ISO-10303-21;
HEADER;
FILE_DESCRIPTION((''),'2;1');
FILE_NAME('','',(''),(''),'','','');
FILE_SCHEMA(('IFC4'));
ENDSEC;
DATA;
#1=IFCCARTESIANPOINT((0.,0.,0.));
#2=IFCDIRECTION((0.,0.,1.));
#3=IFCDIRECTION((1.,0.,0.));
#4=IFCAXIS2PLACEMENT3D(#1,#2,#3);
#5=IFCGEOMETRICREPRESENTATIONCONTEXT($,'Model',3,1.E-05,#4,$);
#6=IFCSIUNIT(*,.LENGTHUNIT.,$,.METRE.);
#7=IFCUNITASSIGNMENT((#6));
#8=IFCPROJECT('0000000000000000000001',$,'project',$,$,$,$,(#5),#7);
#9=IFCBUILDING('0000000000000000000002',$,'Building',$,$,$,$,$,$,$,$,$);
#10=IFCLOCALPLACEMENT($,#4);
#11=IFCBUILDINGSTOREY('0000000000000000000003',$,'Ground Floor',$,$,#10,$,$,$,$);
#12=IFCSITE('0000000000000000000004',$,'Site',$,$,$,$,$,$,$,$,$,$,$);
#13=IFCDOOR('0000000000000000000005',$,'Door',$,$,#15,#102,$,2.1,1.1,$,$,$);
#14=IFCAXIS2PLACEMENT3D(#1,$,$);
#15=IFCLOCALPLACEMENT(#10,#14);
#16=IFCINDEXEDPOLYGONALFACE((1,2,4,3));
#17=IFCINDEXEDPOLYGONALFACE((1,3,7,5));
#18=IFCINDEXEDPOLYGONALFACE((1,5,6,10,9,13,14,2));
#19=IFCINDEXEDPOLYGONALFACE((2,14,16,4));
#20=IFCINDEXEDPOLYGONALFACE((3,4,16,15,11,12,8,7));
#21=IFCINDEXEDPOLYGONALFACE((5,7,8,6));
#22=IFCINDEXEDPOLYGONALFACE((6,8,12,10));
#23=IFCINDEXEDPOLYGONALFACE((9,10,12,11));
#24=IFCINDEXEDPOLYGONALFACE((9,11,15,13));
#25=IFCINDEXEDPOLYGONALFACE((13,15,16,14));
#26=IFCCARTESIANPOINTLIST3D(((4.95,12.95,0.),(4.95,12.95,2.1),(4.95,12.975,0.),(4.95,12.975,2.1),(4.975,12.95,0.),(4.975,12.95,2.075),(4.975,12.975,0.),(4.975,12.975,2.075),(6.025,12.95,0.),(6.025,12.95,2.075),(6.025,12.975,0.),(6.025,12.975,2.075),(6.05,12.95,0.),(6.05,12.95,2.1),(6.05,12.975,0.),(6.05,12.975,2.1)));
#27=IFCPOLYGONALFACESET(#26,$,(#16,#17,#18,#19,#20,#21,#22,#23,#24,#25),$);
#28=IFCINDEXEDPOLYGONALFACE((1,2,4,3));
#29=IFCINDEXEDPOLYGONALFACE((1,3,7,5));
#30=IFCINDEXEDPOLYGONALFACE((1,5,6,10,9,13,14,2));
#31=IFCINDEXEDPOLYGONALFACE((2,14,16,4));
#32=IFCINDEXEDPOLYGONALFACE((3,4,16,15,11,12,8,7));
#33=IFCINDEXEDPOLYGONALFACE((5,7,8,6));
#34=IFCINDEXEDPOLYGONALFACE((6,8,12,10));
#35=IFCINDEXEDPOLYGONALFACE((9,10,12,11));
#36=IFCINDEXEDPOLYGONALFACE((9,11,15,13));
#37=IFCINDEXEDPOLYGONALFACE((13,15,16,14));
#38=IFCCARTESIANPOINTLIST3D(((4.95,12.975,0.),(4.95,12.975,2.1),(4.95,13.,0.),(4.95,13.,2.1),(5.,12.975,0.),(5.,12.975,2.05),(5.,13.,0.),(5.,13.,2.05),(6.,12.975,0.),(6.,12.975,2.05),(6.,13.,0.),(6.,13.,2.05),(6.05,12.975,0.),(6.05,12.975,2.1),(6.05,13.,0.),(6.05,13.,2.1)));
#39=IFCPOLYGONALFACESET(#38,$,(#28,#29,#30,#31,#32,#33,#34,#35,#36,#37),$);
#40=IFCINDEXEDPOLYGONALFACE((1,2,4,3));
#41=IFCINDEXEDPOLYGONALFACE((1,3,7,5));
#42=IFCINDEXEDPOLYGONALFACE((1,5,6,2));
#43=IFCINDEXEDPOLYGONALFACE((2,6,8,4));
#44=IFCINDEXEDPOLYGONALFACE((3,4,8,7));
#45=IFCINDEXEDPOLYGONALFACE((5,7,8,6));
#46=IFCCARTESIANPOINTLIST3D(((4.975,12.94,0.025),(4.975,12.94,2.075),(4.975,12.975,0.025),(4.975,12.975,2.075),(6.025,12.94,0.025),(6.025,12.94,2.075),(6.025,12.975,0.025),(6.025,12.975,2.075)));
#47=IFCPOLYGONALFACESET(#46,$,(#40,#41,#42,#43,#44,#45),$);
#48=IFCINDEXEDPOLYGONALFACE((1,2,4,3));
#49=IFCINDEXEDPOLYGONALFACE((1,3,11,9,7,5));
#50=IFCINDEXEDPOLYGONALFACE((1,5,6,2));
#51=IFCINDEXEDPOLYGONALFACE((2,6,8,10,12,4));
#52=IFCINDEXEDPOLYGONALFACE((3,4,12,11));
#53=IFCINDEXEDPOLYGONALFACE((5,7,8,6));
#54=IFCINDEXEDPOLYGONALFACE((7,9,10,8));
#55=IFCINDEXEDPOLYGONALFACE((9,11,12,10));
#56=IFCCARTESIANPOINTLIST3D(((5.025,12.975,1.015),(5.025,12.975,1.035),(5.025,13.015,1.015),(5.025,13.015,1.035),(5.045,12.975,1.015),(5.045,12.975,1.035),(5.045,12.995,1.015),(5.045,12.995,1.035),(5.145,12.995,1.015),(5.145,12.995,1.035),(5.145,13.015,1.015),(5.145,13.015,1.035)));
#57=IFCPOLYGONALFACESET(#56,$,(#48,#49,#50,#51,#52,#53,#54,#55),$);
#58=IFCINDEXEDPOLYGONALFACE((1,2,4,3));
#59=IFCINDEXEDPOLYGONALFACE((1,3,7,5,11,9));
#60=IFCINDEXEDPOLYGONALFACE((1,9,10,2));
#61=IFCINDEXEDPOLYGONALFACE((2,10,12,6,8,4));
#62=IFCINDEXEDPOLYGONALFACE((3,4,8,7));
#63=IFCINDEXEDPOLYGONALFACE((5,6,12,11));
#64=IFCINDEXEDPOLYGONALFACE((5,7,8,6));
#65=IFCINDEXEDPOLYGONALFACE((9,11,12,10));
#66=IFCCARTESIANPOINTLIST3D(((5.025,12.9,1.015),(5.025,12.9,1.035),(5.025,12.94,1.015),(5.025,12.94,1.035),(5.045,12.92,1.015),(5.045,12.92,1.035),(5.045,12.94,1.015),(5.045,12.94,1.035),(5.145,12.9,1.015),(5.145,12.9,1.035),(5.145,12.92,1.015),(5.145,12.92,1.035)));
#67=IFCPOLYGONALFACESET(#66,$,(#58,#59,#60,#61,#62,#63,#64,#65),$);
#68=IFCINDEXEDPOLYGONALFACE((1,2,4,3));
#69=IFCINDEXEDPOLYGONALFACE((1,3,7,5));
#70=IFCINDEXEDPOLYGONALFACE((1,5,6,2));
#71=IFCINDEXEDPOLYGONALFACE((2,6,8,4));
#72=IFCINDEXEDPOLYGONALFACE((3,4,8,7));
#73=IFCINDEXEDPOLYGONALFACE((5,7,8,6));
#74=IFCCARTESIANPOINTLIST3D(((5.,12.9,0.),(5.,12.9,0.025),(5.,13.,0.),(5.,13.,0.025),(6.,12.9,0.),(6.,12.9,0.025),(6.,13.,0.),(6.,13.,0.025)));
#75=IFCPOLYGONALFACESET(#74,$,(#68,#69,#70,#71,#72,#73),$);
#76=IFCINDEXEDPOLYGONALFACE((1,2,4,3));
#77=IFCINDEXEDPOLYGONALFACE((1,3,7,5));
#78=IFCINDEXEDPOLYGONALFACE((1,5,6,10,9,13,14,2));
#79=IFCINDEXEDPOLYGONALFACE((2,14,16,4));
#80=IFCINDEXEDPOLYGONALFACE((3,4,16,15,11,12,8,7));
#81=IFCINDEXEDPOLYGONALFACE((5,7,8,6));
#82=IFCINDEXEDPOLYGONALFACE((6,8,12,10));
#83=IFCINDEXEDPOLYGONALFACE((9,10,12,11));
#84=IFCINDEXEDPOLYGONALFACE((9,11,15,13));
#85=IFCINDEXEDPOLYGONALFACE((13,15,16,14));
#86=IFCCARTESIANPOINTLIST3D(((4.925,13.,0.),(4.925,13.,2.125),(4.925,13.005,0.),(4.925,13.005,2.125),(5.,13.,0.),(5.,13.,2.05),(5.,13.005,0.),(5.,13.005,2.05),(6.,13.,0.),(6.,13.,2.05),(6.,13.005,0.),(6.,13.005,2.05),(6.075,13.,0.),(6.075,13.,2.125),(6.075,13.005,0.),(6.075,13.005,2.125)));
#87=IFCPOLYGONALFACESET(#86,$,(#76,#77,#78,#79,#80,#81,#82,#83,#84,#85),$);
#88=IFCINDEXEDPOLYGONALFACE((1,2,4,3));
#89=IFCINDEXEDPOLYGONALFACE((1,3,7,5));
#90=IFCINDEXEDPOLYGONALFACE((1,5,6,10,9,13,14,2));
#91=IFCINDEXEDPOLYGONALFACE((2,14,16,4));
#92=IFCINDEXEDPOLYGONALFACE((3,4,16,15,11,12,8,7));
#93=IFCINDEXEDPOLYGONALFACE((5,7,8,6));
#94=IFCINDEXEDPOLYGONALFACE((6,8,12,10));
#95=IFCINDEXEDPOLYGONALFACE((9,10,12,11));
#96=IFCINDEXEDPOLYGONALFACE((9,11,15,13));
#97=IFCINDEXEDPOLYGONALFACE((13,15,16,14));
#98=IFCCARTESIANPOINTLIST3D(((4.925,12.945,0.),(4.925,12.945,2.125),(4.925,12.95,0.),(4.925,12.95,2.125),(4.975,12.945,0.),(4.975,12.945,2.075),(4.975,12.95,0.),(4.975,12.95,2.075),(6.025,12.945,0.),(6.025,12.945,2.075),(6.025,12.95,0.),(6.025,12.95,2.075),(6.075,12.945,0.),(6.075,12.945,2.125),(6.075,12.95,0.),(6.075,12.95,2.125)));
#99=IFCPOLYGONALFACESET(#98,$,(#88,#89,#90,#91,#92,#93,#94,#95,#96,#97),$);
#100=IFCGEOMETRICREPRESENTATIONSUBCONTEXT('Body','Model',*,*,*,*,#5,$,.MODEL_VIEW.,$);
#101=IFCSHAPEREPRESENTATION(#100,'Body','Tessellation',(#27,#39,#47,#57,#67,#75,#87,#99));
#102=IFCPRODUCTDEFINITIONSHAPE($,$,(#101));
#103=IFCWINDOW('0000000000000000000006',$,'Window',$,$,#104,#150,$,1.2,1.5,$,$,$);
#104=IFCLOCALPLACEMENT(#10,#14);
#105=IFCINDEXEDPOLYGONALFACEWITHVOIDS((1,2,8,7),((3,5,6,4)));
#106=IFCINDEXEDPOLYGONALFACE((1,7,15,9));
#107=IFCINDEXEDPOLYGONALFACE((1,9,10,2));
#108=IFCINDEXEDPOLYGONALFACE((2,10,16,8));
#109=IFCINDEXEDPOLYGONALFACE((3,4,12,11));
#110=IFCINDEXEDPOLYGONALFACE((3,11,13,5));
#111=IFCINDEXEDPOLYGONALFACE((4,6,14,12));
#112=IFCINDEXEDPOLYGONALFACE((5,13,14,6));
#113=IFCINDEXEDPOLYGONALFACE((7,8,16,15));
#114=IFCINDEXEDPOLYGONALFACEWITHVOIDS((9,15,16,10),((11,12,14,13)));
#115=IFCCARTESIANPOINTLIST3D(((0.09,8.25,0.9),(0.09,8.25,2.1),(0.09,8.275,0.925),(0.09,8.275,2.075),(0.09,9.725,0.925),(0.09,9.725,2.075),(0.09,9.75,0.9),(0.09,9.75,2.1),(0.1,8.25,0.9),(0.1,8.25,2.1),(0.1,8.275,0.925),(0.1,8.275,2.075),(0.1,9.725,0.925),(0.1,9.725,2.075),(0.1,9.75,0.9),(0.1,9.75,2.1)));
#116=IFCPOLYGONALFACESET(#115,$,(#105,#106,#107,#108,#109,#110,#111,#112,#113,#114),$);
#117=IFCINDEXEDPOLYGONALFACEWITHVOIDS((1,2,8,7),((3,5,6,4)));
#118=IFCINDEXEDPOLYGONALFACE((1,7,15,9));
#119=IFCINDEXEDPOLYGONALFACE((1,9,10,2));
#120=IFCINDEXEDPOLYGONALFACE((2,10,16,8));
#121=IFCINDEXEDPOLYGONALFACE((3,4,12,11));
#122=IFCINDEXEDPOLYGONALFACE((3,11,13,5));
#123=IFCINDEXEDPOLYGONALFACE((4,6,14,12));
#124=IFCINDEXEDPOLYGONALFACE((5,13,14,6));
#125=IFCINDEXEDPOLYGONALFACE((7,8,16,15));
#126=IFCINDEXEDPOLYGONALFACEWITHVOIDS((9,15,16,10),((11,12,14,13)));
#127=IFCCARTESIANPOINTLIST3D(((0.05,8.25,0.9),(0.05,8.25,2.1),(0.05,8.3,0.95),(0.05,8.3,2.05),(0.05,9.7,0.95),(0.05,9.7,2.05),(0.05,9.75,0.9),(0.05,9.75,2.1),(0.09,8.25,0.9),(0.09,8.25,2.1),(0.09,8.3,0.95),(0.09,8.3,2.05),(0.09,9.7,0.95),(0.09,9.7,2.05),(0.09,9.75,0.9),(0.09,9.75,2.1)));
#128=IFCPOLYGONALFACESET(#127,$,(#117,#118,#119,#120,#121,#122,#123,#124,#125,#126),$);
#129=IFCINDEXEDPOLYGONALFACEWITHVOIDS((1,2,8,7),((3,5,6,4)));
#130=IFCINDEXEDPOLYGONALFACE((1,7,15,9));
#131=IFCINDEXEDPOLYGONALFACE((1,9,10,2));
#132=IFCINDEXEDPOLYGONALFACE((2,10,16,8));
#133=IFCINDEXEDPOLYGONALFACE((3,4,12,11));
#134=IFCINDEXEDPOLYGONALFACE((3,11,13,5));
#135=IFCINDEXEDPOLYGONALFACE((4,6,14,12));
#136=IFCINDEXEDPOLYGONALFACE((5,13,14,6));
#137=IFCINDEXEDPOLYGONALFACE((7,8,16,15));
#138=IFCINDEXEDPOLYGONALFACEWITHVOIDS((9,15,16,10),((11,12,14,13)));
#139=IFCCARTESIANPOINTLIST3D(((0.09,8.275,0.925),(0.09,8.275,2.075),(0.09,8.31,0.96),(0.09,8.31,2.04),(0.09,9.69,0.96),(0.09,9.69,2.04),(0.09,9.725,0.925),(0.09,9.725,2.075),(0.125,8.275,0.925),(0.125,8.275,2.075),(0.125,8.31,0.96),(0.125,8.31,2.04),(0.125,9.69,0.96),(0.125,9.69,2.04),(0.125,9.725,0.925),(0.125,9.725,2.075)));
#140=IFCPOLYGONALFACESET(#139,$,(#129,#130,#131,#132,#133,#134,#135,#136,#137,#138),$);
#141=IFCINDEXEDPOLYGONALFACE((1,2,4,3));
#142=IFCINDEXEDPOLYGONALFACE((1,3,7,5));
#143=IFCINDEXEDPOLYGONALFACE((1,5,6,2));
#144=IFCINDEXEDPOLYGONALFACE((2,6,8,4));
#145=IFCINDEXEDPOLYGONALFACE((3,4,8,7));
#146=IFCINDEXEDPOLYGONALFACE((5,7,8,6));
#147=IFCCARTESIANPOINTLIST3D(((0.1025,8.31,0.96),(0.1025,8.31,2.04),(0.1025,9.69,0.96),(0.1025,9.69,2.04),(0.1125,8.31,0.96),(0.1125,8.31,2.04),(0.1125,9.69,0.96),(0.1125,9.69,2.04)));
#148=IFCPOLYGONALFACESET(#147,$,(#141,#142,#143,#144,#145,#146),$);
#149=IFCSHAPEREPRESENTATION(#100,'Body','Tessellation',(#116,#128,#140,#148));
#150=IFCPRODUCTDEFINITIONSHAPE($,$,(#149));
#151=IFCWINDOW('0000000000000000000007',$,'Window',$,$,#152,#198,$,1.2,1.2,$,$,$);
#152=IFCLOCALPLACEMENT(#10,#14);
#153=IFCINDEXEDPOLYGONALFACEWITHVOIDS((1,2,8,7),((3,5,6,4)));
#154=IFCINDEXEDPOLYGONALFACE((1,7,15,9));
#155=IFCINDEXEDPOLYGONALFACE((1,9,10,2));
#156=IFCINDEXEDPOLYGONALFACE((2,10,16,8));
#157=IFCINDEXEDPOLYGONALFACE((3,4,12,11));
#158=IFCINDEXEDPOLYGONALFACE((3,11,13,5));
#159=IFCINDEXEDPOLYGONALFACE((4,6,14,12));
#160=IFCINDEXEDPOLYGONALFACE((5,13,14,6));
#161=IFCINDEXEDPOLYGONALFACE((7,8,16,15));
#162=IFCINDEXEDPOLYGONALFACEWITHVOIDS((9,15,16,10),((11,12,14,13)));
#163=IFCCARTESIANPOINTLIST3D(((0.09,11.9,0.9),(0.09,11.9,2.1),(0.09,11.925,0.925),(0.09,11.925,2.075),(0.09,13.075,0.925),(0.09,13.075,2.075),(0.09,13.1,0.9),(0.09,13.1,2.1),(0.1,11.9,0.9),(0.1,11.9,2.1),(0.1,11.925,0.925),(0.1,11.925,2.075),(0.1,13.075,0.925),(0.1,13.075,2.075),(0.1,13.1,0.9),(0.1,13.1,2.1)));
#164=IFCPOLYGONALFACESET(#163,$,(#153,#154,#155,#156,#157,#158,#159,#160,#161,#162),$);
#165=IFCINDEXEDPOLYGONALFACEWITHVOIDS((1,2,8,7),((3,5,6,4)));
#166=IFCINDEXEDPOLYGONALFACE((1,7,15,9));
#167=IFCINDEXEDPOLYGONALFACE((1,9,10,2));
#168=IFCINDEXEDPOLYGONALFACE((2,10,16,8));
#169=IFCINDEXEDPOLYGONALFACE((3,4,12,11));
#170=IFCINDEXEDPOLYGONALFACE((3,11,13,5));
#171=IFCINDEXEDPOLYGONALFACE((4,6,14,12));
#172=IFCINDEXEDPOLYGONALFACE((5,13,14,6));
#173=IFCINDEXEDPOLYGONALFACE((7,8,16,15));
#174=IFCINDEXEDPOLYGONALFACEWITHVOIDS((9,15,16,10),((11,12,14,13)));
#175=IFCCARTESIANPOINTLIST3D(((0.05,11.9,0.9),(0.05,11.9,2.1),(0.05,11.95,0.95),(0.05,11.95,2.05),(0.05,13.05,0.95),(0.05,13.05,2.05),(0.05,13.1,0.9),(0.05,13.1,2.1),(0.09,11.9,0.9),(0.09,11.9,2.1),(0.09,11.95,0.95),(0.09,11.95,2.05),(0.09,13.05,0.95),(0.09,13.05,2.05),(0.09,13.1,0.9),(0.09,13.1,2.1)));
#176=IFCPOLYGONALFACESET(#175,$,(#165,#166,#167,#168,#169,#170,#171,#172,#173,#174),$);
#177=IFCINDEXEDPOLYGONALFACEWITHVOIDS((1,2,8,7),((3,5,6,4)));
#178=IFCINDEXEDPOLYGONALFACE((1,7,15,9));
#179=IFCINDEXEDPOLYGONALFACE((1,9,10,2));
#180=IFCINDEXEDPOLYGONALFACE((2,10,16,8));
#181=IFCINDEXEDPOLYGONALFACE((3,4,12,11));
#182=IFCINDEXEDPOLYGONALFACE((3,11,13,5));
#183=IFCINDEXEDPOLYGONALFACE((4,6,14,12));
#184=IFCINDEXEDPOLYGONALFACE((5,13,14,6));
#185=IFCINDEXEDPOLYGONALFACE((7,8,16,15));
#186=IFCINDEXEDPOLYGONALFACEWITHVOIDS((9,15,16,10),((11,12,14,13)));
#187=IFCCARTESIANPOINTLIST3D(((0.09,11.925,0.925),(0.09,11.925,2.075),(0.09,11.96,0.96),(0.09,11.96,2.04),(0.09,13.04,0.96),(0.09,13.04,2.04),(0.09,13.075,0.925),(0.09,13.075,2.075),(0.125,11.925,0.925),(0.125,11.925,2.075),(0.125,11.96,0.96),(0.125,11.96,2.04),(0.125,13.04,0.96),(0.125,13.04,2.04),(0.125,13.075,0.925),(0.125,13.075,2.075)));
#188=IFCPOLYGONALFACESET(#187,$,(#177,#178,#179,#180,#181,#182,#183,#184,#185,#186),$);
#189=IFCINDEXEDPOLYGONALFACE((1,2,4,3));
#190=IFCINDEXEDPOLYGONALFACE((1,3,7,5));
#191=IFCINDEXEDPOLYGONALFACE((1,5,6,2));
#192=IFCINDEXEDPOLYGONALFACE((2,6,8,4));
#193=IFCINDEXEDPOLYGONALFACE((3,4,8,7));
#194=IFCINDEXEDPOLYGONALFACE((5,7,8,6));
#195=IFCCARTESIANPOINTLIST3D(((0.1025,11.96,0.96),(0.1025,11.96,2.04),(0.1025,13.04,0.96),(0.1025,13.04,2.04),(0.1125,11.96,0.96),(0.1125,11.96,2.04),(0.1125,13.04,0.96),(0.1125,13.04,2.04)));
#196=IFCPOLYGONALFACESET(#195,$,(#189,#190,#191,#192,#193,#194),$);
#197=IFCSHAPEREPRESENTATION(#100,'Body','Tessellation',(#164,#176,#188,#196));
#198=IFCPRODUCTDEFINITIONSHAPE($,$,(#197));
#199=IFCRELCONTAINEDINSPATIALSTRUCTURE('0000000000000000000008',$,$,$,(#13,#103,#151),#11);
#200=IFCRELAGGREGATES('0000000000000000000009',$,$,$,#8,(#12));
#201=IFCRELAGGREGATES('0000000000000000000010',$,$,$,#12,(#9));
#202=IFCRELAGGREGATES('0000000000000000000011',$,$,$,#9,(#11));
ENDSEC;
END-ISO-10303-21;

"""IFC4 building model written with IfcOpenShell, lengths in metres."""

from ifc_helpers import new_model, si_unit, frame, origin_with_axes, place, context, subcontext, project, spatial, line, indexed_curve, outline, extrude, element, save


model = new_model("IFC4")

# Units and contexts
model_context = context("Model", 3, precision=1e-05, world=origin_with_axes())
body_context = subcontext(model_context, "Body", "Model", "MODEL_VIEW")
ifc_project = project(units=[si_unit("LENGTHUNIT", "METRE")], contexts=[model_context])

# Site, building, storey
site = spatial("IfcSite", under=ifc_project, Name="Site")
building = spatial("IfcBuilding", under=site, Name="Building")
storey_placement = place(None, origin_with_axes())
storey = spatial("IfcBuildingStorey", under=building, at=storey_placement, Name="Ground Floor")

# Door
door_1_placement = place(storey_placement, frame((6.05, 13.0, 0.0), z_axis=(0.0, 0.0, 1.0), x_axis=(-1.0, 0.0, 0.0)))
element("IfcDoor", 1, at=door_1_placement, inside=storey, Name="Door", OverallHeight=2.1, OverallWidth=1.1, context=body_context, shape_type="SweptSolid", body=[
    extrude(outline(indexed_curve([(0.0, 0.0), (0.0, 2.1), (1.1, 2.1), (1.1, 0.0), (1.075, 0.0), (1.075, 2.075), (0.025, 2.075), (0.025, 0.0)], segments=[line(1, 2, 3, 4, 5, 6, 7, 8, 1)])), frame((0.0, 0.025, 0.0), z_axis=(0.0, -1.0, 0.0), x_axis=(1.0, 0.0, 0.0)), (0.0, 0.0, -1.0), 0.025),
    extrude(outline(indexed_curve([(0.0, 0.0), (0.0, 2.1), (1.1, 2.1), (1.1, 0.0), (1.05, 0.0), (1.05, 2.05), (0.05, 2.05), (0.05, 0.0)], segments=[line(1, 2, 3, 4, 5, 6, 7, 8, 1)])), frame((0.0, 0.0, 0.0), z_axis=(0.0, -1.0, 0.0), x_axis=(1.0, 0.0, 0.0)), (0.0, 0.0, -1.0), 0.025),
    extrude(outline(indexed_curve([(0.0, 0.0), (1.05, 0.0), (1.05, 0.035), (0.0, 0.035)], segments=[line(1, 2, 3, 4, 1)])), frame((0.025, 0.025, 0.025), z_axis=(0.0, 0.0, 1.0), x_axis=(1.0, 0.0, 0.0)), (0.0, 0.0, 1.0), 2.05),
    extrude(outline(indexed_curve([(0.0, 0.0), (0.0, -0.04), (-0.12, -0.04), (-0.12, -0.02), (-0.02, -0.02), (-0.02, 0.0)], segments=[line(1, 2, 3, 4, 5, 6, 1)])), frame((1.025, 0.025, 1.015), z_axis=(0.0, 0.0, 1.0), x_axis=(1.0, 0.0, 0.0)), (0.0, 0.0, 1.0), 0.02),
    extrude(outline(indexed_curve([(0.0, 0.0), (0.0, 0.04), (-0.12, 0.04), (-0.12, 0.02), (-0.02, 0.02), (-0.02, 0.0)], segments=[line(1, 2, 3, 4, 5, 6, 1)])), frame((1.025, 0.06, 1.015), z_axis=(0.0, 0.0, 1.0), x_axis=(1.0, 0.0, 0.0)), (0.0, 0.0, 1.0), 0.02),
    extrude(outline(indexed_curve([(0.0, 0.0), (1.0, 0.0), (1.0, 0.1), (0.0, 0.1)], segments=[line(1, 2, 3, 4, 1)])), frame((0.05, 0.0, 0.0), z_axis=(0.0, 0.0, 1.0), x_axis=(1.0, 0.0, 0.0)), (0.0, 0.0, 1.0), 0.025),
    extrude(outline(indexed_curve([(0.0, 0.0), (0.0, 2.125), (1.15, 2.125), (1.15, 0.0), (1.075, 0.0), (1.075, 2.05), (0.075, 2.05), (0.075, 0.0)], segments=[line(1, 2, 3, 4, 5, 6, 7, 8, 1)])), frame((-0.025, -0.005, 0.0), z_axis=(0.0, -1.0, 0.0), x_axis=(1.0, 0.0, 0.0)), (0.0, 0.0, -1.0), 0.005),
    extrude(outline(indexed_curve([(0.0, 0.0), (0.0, 2.125), (1.15, 2.125), (1.15, 0.0), (1.1, 0.0), (1.1, 2.075), (0.05, 2.075), (0.05, 0.0)], segments=[line(1, 2, 3, 4, 5, 6, 7, 8, 1)])), frame((-0.025, 0.05, 0.0), z_axis=(0.0, -1.0, 0.0), x_axis=(1.0, 0.0, 0.0)), (0.0, 0.0, -1.0), 0.005),
])

# Windows
window_1_placement = place(storey_placement, frame((0.0, 9.75, 0.9), z_axis=(0.0, 0.0, 1.0), x_axis=(0.0, -1.0, 0.0)))
element("IfcWindow", 2, at=window_1_placement, inside=storey, Name="Window", OverallHeight=1.2, OverallWidth=1.5, context=body_context, shape_type="SweptSolid", body=[
    extrude(outline(indexed_curve([(0.0, 0.0), (1.5, 0.0), (1.5, 1.2), (0.0, 1.2)], segments=[line(1, 2, 3, 4, 1)]), holes=[indexed_curve([(0.025, 0.025), (1.475, 0.025), (1.475, 1.175), (0.025, 1.175)], segments=[line(1, 2, 3, 4, 1)])]), frame((0.0, 0.09, 0.0), z_axis=(0.0, -1.0, 0.0), x_axis=(1.0, 0.0, 0.0)), (0.0, 0.0, -1.0), 0.01),
    extrude(outline(indexed_curve([(0.0, 0.0), (1.5, 0.0), (1.5, 1.2), (0.0, 1.2)], segments=[line(1, 2, 3, 4, 1)]), holes=[indexed_curve([(0.05, 0.05), (1.45, 0.05), (1.45, 1.15), (0.05, 1.15)], segments=[line(1, 2, 3, 4, 1)])]), frame((0.0, 0.05, 0.0), z_axis=(0.0, -1.0, 0.0), x_axis=(1.0, 0.0, 0.0)), (0.0, 0.0, -1.0), 0.04),
    extrude(outline(indexed_curve([(0.0, 0.0), (1.45, 0.0), (1.45, 1.15), (0.0, 1.15)], segments=[line(1, 2, 3, 4, 1)]), holes=[indexed_curve([(0.035, 0.035), (1.415, 0.035), (1.415, 1.115), (0.035, 1.115)], segments=[line(1, 2, 3, 4, 1)])]), frame((0.025, 0.09, 0.025), z_axis=(0.0, -1.0, 0.0), x_axis=(1.0, 0.0, 0.0)), (0.0, 0.0, -1.0), 0.035),
    extrude(outline(indexed_curve([(0.035, 0.035), (1.415, 0.035), (1.415, 1.115), (0.035, 1.115)], segments=[line(1, 2, 3, 4, 1)])), frame((0.025, 0.1025, 0.025), z_axis=(0.0, -1.0, 0.0), x_axis=(1.0, 0.0, 0.0)), (0.0, 0.0, -1.0), 0.01),
])
for number, where, z_axis, x_axis, name in (
    (3, (0.0, 13.1, 0.9), (0.0, 0.0, 1.0), (0.0, -1.0, 0.0), "Window"),
):
    element("IfcWindow", number, at=place(storey_placement, frame(where, z_axis=z_axis, x_axis=x_axis)), inside=storey, Name=name, OverallHeight=1.2, OverallWidth=1.2, context=body_context, shape_type="SweptSolid", body=[
        extrude(outline(indexed_curve([(0.0, 0.0), (1.2, 0.0), (1.2, 1.2), (0.0, 1.2)], segments=[line(1, 2, 3, 4, 1)]), holes=[indexed_curve([(0.025, 0.025), (1.175, 0.025), (1.175, 1.175), (0.025, 1.175)], segments=[line(1, 2, 3, 4, 1)])]), frame((0.0, 0.09, 0.0), z_axis=(0.0, -1.0, 0.0), x_axis=(1.0, 0.0, 0.0)), (0.0, 0.0, -1.0), 0.01),
        extrude(outline(indexed_curve([(0.0, 0.0), (1.2, 0.0), (1.2, 1.2), (0.0, 1.2)], segments=[line(1, 2, 3, 4, 1)]), holes=[indexed_curve([(0.05, 0.05), (1.15, 0.05), (1.15, 1.15), (0.05, 1.15)], segments=[line(1, 2, 3, 4, 1)])]), frame((0.0, 0.05, 0.0), z_axis=(0.0, -1.0, 0.0), x_axis=(1.0, 0.0, 0.0)), (0.0, 0.0, -1.0), 0.04),
        extrude(outline(indexed_curve([(0.0, 0.0), (1.15, 0.0), (1.15, 1.15), (0.0, 1.15)], segments=[line(1, 2, 3, 4, 1)]), holes=[indexed_curve([(0.035, 0.035), (1.115, 0.035), (1.115, 1.115), (0.035, 1.115)], segments=[line(1, 2, 3, 4, 1)])]), frame((0.025, 0.09, 0.025), z_axis=(0.0, -1.0, 0.0), x_axis=(1.0, 0.0, 0.0)), (0.0, 0.0, -1.0), 0.035),
        extrude(outline(indexed_curve([(0.035, 0.035), (1.115, 0.035), (1.115, 1.115), (0.035, 1.115)], segments=[line(1, 2, 3, 4, 1)])), frame((0.025, 0.1025, 0.025), z_axis=(0.0, -1.0, 0.0), x_axis=(1.0, 0.0, 0.0)), (0.0, 0.0, -1.0), 0.01),
    ])

save(model, "model.ifc")
